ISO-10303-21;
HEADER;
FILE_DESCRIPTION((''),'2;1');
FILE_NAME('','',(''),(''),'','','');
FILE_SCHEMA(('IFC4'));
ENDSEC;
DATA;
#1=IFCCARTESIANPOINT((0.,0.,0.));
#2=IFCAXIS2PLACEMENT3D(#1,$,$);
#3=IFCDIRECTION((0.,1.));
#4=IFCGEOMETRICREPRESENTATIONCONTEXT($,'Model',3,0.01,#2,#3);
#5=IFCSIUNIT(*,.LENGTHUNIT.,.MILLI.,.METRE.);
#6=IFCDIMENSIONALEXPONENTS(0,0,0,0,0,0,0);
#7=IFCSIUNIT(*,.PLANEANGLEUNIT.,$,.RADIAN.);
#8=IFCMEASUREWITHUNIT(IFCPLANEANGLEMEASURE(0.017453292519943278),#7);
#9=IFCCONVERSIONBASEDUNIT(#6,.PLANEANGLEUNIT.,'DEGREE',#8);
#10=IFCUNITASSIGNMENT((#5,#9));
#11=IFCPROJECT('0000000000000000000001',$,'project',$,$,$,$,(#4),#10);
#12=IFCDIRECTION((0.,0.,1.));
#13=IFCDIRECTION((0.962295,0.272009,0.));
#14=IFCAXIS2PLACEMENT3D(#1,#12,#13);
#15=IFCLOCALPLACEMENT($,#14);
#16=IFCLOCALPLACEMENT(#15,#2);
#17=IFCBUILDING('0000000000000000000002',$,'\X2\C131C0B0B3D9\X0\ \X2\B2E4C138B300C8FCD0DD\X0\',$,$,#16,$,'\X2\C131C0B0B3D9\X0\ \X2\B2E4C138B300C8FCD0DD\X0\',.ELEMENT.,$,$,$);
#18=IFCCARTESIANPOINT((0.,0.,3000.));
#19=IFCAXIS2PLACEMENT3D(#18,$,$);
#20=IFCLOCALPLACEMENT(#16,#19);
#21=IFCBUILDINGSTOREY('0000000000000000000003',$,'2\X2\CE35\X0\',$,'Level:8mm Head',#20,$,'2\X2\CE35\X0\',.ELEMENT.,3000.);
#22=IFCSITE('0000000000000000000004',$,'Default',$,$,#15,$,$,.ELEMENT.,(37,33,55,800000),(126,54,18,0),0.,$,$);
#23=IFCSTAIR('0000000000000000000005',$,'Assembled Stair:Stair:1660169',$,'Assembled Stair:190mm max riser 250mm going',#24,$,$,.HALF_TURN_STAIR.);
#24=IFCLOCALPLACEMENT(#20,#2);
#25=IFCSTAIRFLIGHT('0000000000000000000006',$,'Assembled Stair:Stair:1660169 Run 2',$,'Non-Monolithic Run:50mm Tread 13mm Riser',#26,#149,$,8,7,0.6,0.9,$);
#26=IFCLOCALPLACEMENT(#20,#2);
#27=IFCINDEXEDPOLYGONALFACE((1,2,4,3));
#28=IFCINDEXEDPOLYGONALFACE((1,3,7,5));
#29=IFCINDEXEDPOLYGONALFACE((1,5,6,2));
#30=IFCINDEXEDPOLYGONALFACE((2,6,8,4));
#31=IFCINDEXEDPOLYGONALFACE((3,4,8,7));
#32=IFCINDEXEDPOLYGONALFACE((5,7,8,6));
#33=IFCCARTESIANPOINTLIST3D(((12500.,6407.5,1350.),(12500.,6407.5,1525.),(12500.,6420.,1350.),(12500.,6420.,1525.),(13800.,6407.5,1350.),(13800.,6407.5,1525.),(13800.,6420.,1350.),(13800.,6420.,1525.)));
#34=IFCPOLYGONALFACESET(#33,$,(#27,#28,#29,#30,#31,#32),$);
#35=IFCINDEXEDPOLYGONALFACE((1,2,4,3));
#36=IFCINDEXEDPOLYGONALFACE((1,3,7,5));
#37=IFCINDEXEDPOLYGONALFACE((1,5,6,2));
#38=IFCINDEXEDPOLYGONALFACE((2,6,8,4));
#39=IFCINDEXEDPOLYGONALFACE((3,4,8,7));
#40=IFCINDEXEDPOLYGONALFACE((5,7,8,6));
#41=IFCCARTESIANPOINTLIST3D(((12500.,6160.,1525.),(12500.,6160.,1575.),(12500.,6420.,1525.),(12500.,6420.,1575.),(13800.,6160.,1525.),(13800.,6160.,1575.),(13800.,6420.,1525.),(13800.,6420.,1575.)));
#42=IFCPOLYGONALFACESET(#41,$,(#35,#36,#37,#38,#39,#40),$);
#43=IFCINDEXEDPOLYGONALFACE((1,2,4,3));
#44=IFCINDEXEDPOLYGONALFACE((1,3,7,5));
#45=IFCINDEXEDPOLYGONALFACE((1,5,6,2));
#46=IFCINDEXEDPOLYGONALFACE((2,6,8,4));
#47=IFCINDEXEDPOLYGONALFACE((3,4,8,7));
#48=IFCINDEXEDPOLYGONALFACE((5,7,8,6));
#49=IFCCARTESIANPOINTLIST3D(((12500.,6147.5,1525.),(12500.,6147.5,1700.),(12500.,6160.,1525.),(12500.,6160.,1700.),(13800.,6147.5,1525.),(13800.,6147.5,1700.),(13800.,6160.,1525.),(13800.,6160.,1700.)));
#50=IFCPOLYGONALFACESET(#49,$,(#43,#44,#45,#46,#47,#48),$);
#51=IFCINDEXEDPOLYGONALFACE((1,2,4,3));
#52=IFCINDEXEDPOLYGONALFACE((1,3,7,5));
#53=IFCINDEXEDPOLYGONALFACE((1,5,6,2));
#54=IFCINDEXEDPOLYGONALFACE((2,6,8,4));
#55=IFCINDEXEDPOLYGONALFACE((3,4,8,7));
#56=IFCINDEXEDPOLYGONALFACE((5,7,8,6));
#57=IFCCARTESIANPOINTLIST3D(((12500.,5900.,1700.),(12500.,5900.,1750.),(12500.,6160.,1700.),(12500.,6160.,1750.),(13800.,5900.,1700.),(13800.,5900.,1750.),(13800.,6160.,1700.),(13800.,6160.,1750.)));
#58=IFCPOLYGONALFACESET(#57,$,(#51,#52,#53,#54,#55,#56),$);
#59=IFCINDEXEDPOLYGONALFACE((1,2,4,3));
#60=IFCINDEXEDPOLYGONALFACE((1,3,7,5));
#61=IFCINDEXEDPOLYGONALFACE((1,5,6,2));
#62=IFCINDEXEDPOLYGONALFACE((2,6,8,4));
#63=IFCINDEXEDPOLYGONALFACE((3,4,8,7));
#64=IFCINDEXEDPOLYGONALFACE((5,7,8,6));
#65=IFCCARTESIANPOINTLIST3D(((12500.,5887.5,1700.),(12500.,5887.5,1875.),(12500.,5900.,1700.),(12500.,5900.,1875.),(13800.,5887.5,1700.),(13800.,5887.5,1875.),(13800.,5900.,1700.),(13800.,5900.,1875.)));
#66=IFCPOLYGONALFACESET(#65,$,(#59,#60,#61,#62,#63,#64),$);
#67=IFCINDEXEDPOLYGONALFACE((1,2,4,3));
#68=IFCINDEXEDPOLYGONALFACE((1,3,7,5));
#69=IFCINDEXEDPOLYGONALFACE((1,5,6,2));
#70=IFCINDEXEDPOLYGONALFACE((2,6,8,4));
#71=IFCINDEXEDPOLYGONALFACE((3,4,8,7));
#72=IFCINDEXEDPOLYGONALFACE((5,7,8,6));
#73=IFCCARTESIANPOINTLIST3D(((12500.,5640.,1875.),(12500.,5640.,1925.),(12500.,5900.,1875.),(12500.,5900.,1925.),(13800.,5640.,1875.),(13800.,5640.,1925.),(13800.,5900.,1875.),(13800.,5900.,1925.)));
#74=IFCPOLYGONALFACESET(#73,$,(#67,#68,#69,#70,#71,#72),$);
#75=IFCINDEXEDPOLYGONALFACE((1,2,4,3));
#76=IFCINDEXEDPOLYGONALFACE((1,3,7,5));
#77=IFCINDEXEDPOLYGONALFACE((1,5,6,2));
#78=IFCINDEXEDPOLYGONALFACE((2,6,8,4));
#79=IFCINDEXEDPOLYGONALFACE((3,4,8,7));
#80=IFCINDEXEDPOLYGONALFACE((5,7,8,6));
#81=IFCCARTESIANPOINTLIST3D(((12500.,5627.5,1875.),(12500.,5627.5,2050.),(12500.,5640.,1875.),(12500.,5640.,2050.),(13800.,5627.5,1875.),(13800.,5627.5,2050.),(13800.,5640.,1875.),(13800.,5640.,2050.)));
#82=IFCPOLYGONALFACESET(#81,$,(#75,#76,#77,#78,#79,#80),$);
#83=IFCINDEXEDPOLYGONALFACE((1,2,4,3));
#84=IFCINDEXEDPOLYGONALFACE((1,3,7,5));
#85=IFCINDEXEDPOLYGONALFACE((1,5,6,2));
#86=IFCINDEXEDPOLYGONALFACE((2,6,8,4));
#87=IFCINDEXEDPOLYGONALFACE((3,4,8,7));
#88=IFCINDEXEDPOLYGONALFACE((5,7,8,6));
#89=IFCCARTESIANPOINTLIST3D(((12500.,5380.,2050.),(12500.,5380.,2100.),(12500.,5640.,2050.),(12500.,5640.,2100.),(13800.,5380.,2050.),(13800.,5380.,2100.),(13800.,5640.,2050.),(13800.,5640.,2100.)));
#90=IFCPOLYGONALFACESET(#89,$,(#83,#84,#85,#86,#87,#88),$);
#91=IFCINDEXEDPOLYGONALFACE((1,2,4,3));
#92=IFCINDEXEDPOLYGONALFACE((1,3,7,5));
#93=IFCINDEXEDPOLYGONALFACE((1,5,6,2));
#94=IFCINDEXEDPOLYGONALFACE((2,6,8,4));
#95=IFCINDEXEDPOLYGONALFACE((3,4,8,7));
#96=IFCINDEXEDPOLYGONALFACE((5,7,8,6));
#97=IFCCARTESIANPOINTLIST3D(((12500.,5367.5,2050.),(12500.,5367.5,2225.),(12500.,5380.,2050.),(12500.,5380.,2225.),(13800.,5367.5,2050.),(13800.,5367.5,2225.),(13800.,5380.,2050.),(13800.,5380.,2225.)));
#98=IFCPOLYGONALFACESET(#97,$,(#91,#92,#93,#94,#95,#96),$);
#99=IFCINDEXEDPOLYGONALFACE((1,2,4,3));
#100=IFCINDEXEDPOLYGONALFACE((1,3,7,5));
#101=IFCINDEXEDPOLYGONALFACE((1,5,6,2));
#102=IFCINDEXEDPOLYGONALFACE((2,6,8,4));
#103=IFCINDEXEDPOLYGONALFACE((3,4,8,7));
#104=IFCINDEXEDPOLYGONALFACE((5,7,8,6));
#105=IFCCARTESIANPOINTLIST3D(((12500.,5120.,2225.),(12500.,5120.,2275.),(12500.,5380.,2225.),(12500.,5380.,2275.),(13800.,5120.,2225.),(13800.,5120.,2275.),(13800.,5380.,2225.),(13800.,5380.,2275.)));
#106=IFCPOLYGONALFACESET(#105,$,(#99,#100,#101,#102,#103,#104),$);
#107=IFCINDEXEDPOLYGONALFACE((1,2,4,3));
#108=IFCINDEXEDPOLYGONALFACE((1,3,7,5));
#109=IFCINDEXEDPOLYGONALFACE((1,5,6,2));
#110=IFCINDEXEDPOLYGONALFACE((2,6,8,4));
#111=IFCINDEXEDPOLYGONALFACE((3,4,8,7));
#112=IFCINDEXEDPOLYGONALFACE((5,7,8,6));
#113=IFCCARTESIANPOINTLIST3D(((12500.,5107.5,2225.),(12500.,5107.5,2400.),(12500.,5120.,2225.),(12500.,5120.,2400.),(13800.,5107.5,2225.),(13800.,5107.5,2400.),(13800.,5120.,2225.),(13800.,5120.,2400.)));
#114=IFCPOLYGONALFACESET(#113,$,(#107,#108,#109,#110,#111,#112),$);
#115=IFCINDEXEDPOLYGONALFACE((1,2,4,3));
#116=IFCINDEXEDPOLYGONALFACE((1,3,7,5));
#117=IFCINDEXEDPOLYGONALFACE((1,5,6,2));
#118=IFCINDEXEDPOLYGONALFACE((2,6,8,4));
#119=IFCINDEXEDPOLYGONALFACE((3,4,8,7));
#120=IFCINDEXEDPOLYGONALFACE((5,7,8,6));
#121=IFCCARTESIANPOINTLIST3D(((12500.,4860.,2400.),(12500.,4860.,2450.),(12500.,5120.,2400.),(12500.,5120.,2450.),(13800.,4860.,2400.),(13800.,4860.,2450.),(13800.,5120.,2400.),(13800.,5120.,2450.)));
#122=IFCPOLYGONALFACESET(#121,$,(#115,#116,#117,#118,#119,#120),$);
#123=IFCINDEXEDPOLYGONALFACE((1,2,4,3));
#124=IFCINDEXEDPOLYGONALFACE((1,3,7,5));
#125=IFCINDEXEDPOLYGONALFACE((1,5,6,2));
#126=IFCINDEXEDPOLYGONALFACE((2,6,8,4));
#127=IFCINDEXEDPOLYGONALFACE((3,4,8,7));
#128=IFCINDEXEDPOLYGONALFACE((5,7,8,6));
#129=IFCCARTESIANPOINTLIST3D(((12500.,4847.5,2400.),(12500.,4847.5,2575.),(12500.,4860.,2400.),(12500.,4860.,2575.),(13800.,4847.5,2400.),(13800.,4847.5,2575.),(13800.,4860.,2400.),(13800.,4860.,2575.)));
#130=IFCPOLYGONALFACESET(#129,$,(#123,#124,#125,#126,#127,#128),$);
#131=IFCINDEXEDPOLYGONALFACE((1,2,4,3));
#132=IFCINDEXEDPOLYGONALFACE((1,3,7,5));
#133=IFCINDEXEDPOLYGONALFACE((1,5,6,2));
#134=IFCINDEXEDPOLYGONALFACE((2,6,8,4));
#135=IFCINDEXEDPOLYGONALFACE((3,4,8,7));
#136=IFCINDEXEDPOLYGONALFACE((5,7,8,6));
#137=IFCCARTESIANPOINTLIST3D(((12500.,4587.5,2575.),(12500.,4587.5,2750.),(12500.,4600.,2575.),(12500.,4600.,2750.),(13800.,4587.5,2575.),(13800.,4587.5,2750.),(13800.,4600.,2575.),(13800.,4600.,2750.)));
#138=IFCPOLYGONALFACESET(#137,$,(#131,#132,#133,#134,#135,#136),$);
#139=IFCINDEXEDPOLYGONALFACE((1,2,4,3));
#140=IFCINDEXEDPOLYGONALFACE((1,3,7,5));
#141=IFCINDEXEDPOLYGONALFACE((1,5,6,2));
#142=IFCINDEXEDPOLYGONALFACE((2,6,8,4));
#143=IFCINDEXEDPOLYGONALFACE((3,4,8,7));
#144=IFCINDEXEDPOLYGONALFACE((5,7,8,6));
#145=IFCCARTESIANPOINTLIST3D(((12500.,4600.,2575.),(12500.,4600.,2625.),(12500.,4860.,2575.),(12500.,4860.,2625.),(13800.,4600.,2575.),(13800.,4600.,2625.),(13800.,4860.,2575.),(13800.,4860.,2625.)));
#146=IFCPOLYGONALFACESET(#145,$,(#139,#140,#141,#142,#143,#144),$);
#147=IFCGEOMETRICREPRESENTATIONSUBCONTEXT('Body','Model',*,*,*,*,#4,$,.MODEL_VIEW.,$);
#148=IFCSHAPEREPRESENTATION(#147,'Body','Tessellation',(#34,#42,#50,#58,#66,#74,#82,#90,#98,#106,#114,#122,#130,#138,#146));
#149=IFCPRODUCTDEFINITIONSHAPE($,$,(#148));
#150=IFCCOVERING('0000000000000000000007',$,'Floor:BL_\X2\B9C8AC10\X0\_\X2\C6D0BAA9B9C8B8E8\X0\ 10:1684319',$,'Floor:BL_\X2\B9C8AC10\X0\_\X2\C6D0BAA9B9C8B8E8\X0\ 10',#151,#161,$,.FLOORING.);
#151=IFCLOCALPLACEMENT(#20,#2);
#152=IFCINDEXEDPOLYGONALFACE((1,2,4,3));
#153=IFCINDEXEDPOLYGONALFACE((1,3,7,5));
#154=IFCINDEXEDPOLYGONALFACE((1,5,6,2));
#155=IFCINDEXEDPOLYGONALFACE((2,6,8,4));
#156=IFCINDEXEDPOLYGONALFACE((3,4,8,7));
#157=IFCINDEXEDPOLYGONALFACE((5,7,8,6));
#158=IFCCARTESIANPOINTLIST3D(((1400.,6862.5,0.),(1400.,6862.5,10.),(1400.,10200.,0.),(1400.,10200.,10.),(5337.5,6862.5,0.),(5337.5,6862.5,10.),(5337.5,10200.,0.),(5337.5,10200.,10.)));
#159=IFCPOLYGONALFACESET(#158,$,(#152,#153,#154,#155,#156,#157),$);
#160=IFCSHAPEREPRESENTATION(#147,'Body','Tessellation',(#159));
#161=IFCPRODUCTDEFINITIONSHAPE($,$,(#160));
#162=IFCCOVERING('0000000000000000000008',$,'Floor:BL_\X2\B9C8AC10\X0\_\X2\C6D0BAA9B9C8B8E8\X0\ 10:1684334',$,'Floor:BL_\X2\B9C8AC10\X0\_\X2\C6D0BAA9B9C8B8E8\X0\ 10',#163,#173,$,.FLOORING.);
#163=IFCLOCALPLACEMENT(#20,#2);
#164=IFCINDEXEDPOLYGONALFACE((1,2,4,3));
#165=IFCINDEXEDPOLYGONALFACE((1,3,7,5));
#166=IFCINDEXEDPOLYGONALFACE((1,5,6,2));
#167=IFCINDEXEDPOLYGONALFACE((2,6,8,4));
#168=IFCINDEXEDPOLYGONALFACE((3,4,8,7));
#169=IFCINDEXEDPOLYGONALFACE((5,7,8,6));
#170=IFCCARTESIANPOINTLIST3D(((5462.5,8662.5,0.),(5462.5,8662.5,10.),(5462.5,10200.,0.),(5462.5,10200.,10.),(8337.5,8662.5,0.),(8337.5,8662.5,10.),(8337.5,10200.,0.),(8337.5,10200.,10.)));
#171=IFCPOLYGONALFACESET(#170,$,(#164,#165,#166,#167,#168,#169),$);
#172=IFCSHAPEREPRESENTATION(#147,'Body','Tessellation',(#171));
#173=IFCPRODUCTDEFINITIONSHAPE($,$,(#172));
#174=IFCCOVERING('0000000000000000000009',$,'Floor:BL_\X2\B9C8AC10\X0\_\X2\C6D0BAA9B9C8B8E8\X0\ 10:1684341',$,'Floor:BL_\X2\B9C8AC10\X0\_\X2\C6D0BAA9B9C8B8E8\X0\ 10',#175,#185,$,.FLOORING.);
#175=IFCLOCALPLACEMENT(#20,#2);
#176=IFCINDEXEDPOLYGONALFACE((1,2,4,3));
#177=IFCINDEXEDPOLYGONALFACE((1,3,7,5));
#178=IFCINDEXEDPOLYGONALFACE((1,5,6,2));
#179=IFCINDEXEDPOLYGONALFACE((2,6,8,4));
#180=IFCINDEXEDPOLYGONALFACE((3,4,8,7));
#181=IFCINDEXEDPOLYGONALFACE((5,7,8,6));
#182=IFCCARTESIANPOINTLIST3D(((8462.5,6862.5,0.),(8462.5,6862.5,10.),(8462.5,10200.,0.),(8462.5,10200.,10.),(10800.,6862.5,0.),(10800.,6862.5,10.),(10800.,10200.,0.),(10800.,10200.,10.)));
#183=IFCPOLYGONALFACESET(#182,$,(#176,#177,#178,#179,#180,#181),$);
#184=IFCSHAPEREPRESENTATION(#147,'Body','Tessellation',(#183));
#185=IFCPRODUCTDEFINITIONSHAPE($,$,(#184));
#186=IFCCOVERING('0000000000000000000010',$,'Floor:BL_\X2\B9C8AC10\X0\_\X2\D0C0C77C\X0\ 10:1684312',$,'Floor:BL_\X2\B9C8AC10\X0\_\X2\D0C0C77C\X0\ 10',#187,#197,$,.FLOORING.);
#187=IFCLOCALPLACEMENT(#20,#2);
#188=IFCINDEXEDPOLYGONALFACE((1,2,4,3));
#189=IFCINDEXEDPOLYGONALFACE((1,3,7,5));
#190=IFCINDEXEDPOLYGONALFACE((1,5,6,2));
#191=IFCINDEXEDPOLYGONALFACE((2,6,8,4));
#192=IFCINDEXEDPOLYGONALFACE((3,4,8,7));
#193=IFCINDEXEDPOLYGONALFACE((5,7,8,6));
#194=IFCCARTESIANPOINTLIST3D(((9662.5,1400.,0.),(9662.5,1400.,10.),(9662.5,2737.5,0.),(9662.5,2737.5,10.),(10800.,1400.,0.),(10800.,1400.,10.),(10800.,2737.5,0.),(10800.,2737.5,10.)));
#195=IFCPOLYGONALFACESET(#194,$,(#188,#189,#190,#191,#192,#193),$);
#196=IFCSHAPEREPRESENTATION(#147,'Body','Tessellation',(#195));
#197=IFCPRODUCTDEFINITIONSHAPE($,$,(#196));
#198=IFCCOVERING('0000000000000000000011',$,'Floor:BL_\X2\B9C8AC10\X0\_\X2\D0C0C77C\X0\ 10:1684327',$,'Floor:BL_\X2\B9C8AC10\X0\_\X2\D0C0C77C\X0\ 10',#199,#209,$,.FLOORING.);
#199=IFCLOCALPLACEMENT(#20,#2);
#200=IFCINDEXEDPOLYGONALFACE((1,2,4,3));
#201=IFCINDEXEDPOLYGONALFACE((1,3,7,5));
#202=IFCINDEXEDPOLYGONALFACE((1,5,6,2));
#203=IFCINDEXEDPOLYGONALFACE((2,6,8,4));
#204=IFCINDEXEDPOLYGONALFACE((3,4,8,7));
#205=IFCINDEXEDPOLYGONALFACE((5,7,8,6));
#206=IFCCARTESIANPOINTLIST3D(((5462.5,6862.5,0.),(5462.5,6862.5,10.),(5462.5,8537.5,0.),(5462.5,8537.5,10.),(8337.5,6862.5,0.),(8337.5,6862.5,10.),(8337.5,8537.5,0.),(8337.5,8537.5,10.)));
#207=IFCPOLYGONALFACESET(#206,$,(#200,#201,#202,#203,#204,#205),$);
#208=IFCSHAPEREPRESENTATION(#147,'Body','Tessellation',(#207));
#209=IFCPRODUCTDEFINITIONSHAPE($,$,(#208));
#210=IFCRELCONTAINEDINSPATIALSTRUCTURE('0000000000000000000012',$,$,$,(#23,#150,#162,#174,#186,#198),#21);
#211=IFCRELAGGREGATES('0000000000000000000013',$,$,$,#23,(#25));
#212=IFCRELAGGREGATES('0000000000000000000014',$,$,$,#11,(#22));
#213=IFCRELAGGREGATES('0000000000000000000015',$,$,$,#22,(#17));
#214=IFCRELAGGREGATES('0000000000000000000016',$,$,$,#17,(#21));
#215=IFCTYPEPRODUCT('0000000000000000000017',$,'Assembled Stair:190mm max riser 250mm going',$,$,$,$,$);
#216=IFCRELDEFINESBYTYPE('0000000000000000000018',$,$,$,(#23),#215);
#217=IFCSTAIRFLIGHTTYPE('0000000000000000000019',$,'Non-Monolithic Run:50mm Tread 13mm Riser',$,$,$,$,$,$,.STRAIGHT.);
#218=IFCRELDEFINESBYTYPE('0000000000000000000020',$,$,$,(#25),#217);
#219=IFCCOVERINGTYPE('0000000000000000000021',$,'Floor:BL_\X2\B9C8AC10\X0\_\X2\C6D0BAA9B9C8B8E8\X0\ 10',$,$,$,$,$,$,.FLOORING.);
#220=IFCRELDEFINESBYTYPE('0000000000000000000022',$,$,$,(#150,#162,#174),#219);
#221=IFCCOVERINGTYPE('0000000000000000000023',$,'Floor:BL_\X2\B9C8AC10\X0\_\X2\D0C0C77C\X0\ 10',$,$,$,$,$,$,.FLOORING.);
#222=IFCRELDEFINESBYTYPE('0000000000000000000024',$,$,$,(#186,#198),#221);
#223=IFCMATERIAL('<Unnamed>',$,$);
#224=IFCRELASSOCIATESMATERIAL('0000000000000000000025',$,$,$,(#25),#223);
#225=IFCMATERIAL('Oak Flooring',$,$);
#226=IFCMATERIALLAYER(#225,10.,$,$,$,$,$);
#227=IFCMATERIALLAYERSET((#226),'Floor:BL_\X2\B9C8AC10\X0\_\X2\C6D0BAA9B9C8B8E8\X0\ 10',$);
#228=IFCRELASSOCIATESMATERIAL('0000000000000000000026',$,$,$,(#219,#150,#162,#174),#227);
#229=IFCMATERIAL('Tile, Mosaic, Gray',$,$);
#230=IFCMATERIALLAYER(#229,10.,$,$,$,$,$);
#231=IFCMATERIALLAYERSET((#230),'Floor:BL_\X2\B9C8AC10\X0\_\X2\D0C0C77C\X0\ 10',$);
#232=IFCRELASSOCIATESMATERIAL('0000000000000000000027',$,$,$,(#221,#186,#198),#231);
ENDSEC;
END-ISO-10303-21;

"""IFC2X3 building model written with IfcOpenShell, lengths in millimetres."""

from ifc_helpers import new_model, entity, si_unit, converted_unit, direction, frame, frame_2d, origin, origin_2d_with_axis, place, context, subcontext, project, spatial, rectangle, extrude, material, layer, layer_set, layer_usage, type_object, element, aggregate, save


model = new_model("IFC2X3")

# Units and contexts
model_context = context("Model", 3, precision=0.01, world=origin(), true_north=direction((0.0, 1.0)))
body_context = subcontext(model_context, "Body", "Model", "MODEL_VIEW")
ifc_project = project(units=[si_unit("LENGTHUNIT", "METRE", prefix="MILLI"), converted_unit("PLANEANGLEUNIT", "DEGREE", entity("IfcPlaneAngleMeasure", 0.017453292519943278), si_unit("PLANEANGLEUNIT", "RADIAN"), dimensions=[0, 0, 0, 0, 0, 0, 0])], contexts=[model_context])

# Site, building, storey
site_placement = place(None, frame((0.0, 0.0, 0.0), z_axis=(0.0, 0.0, 1.0), x_axis=(0.962295, 0.272009, 0.0)))
site = spatial("IfcSite", under=ifc_project, at=site_placement, Name="Default", CompositionType="ELEMENT", RefLatitude=(37, 33, 55, 800000), RefLongitude=(126, 54, 18, 0), RefElevation=0.0)
building_placement = place(site_placement, origin())
building = spatial("IfcBuilding", under=site, at=building_placement, Name="성산동 다세대주택", LongName="성산동 다세대주택", CompositionType="ELEMENT")
storey_placement = place(building_placement, frame((0.0, 0.0, 3000.0)))
storey = spatial("IfcBuildingStorey", under=building, at=storey_placement, Name="2층", ObjectType="Level:8mm Head", LongName="2층", CompositionType="ELEMENT", Elevation=3000.0)

# Stair
type_product = type_object("IfcTypeProduct", Name="Assembled Stair:190mm max riser 250mm going")
stair_placement = place(storey_placement, origin())
stair = element("IfcStair", 1, at=stair_placement, inside=storey, type_object=type_product, Name="Assembled Stair:Stair:1660169", ObjectType="Assembled Stair:190mm max riser 250mm going", ShapeType="HALF_TURN_STAIR")
ifc_material_1 = material(Name="<Unnamed>")

# Stair flight
stair_flight_type = type_object("IfcStairFlightType", Name="Non-Monolithic Run:50mm Tread 13mm Riser", PredefinedType="STRAIGHT")
stair_flight_1_placement = place(stair_placement, origin())
stair_flight_1 = element("IfcStairFlight", 2, at=stair_flight_1_placement, type_object=stair_flight_type, material=ifc_material_1, Name="Assembled Stair:Stair:1660169 Run 2", ObjectType="Non-Monolithic Run:50mm Tread 13mm Riser", NumberOfRiser=8, NumberOfTreads=7, RiserHeight=0.6, TreadLength=0.9, context=body_context, shape_type="SweptSolid", body=[
    extrude(rectangle(XDim=1300.0, YDim=12.5, at=frame_2d((0.0, 0.0), x_axis=(1.0, 0.0))), frame((13150.0, 6413.7, 1350.0)), (0.0, 0.0, 1.0), 175.0),
    extrude(rectangle(XDim=260.0, YDim=1300.0, at=frame_2d((0.0, 0.0), x_axis=(1.0, 0.0))), frame((13150.0, 6290.0, 1525.0), z_axis=(0.0, 0.0, 1.0), x_axis=(0.0, 1.0, 0.0)), (0.0, 0.0, 1.0), 50.0),
    extrude(rectangle(XDim=1300.0, YDim=12.5, at=frame_2d((0.0, 0.0), x_axis=(1.0, 0.0))), frame((13150.0, 6153.7, 1525.0)), (0.0, 0.0, 1.0), 175.0),
    extrude(rectangle(XDim=260.0, YDim=1300.0, at=origin_2d_with_axis()), frame((13150.0, 6030.0, 1700.0), z_axis=(0.0, 0.0, 1.0), x_axis=(0.0, 1.0, 0.0)), (0.0, 0.0, 1.0), 50.0),
    extrude(rectangle(XDim=1300.0, YDim=12.5, at=frame_2d((0.0, 0.0), x_axis=(1.0, 0.0))), frame((13150.0, 5893.7, 1700.0)), (0.0, 0.0, 1.0), 175.0),
    extrude(rectangle(XDim=260.0, YDim=1300.0, at=origin_2d_with_axis()), frame((13150.0, 5770.0, 1875.0), z_axis=(0.0, 0.0, 1.0), x_axis=(0.0, 1.0, 0.0)), (0.0, 0.0, 1.0), 50.0),
    extrude(rectangle(XDim=1300.0, YDim=12.5, at=frame_2d((0.0, 0.0), x_axis=(1.0, 0.0))), frame((13150.0, 5633.7, 1875.0)), (0.0, 0.0, 1.0), 175.0),
    extrude(rectangle(XDim=260.0, YDim=1300.0, at=origin_2d_with_axis()), frame((13150.0, 5510.0, 2050.0), z_axis=(0.0, 0.0, 1.0), x_axis=(0.0, 1.0, 0.0)), (0.0, 0.0, 1.0), 50.0),
    extrude(rectangle(XDim=1300.0, YDim=12.5, at=frame_2d((0.0, 0.0), x_axis=(1.0, 0.0))), frame((13150.0, 5373.7, 2050.0)), (0.0, 0.0, 1.0), 175.0),
    extrude(rectangle(XDim=260.0, YDim=1300.0, at=origin_2d_with_axis()), frame((13150.0, 5250.0, 2225.0), z_axis=(0.0, 0.0, 1.0), x_axis=(0.0, 1.0, 0.0)), (0.0, 0.0, 1.0), 50.0),
    extrude(rectangle(XDim=1300.0, YDim=12.5, at=frame_2d((0.0, 0.0), x_axis=(1.0, 0.0))), frame((13150.0, 5113.7, 2225.0)), (0.0, 0.0, 1.0), 175.0),
    extrude(rectangle(XDim=260.0, YDim=1300.0, at=origin_2d_with_axis()), frame((13150.0, 4990.0, 2400.0), z_axis=(0.0, 0.0, 1.0), x_axis=(0.0, 1.0, 0.0)), (0.0, 0.0, 1.0), 50.0),
    extrude(rectangle(XDim=1300.0, YDim=12.5, at=frame_2d((0.0, 0.0), x_axis=(1.0, 0.0))), frame((13150.0, 4853.7, 2400.0)), (0.0, 0.0, 1.0), 175.0),
    extrude(rectangle(XDim=1300.0, YDim=12.5, at=frame_2d((0.0, 0.0), x_axis=(1.0, 0.0))), frame((13150.0, 4593.8, 2575.0)), (0.0, 0.0, 1.0), 175.0),
    extrude(rectangle(XDim=260.0, YDim=1300.0, at=origin_2d_with_axis()), frame((13150.0, 4730.0, 2575.0), z_axis=(0.0, 0.0, 1.0), x_axis=(0.0, 1.0, 0.0)), (0.0, 0.0, 1.0), 50.0),
])
aggregate(stair, [stair_flight_1])

# Coverings
ifc_material_2 = material(Name="Oak Flooring")
ifc_layer_1 = layer(ifc_material_2, 10.0)
ifc_layer_set_1 = layer_set([ifc_layer_1], Name="Floor:BL_마감_원목마루 10")
covering_type_1 = type_object("IfcCoveringType", Name="Floor:BL_마감_원목마루 10", PredefinedType="FLOORING", material=ifc_layer_set_1)
ifc_layer_usage_1 = layer_usage(ifc_layer_set_1, "AXIS3", "POSITIVE", 0.0)
covering_1_placement = place(storey_placement, origin())
element("IfcCovering", 3, at=covering_1_placement, inside=storey, type_object=covering_type_1, material=ifc_layer_usage_1, Name="Floor:BL_마감_원목마루 10:1684319", ObjectType="Floor:BL_마감_원목마루 10", PredefinedType="FLOORING", context=body_context, shape_type="SweptSolid", body=[
    extrude(rectangle(XDim=3337.5, YDim=3937.5, at=frame_2d((0.0, 0.0), x_axis=(1.0, 0.0))), frame((3368.8, 8531.3, 10.0), z_axis=(0.0, 0.0, -1.0), x_axis=(0.0, 1.0, 0.0)), (0.0, 0.0, 1.0), 10.0),
])
ifc_layer_usage_2 = layer_usage(ifc_layer_set_1, "AXIS3", "POSITIVE", 0.0)
covering_2_placement = place(storey_placement, origin())
element("IfcCovering", 4, at=covering_2_placement, inside=storey, type_object=covering_type_1, material=ifc_layer_usage_2, Name="Floor:BL_마감_원목마루 10:1684334", ObjectType="Floor:BL_마감_원목마루 10", PredefinedType="FLOORING", context=body_context, shape_type="SweptSolid", body=[
    extrude(rectangle(XDim=1537.5, YDim=2875.0, at=frame_2d((0.0, 0.0), x_axis=(1.0, 0.0))), frame((6900.0, 9431.2, 10.0), z_axis=(0.0, 0.0, -1.0), x_axis=(0.0, 1.0, 0.0)), (0.0, 0.0, 1.0), 10.0),
])
ifc_layer_usage_3 = layer_usage(ifc_layer_set_1, "AXIS3", "POSITIVE", 0.0)
covering_3_placement = place(storey_placement, origin())
element("IfcCovering", 5, at=covering_3_placement, inside=storey, type_object=covering_type_1, material=ifc_layer_usage_3, Name="Floor:BL_마감_원목마루 10:1684341", ObjectType="Floor:BL_마감_원목마루 10", PredefinedType="FLOORING", context=body_context, shape_type="SweptSolid", body=[
    extrude(rectangle(XDim=2337.5, YDim=3337.5, at=frame_2d((0.0, 0.0), x_axis=(1.0, 0.0))), frame((9631.2, 8531.2, 10.0), z_axis=(0.0, 0.0, -1.0), x_axis=(1.0, 0.0, 0.0)), (0.0, 0.0, 1.0), 10.0),
])
ifc_material_3 = material(Name="Tile, Mosaic, Gray")
ifc_layer_2 = layer(ifc_material_3, 10.0)
ifc_layer_set_2 = layer_set([ifc_layer_2], Name="Floor:BL_마감_타일 10")
ifc_layer_usage_4 = layer_usage(ifc_layer_set_2, "AXIS3", "POSITIVE", 0.0)
covering_type_2 = type_object("IfcCoveringType", Name="Floor:BL_마감_타일 10", PredefinedType="FLOORING", material=ifc_layer_set_2)
covering_4_placement = place(storey_placement, origin())
element("IfcCovering", 6, at=covering_4_placement, inside=storey, type_object=covering_type_2, material=ifc_layer_usage_4, Name="Floor:BL_마감_타일 10:1684312", ObjectType="Floor:BL_마감_타일 10", PredefinedType="FLOORING", context=body_context, shape_type="SweptSolid", body=[
    extrude(rectangle(XDim=1337.5, YDim=1137.5, at=frame_2d((0.0, 0.0), x_axis=(1.0, 0.0))), frame((10231.2, 2068.8, 10.0), z_axis=(0.0, 0.0, -1.0), x_axis=(0.0, 1.0, 0.0)), (0.0, 0.0, 1.0), 10.0),
])
ifc_layer_usage_5 = layer_usage(ifc_layer_set_2, "AXIS3", "POSITIVE", 0.0)
covering_5_placement = place(storey_placement, origin())
element("IfcCovering", 7, at=covering_5_placement, inside=storey, type_object=covering_type_2, material=ifc_layer_usage_5, Name="Floor:BL_마감_타일 10:1684327", ObjectType="Floor:BL_마감_타일 10", PredefinedType="FLOORING", context=body_context, shape_type="SweptSolid", body=[
    extrude(rectangle(XDim=1675.0, YDim=2875.0, at=frame_2d((0.0, 0.0), x_axis=(1.0, 0.0))), frame((6900.0, 7700.0, 10.0), z_axis=(0.0, 0.0, -1.0), x_axis=(0.0, 1.0, 0.0)), (0.0, 0.0, 1.0), 10.0),
])

save(model, "model.ifc")
